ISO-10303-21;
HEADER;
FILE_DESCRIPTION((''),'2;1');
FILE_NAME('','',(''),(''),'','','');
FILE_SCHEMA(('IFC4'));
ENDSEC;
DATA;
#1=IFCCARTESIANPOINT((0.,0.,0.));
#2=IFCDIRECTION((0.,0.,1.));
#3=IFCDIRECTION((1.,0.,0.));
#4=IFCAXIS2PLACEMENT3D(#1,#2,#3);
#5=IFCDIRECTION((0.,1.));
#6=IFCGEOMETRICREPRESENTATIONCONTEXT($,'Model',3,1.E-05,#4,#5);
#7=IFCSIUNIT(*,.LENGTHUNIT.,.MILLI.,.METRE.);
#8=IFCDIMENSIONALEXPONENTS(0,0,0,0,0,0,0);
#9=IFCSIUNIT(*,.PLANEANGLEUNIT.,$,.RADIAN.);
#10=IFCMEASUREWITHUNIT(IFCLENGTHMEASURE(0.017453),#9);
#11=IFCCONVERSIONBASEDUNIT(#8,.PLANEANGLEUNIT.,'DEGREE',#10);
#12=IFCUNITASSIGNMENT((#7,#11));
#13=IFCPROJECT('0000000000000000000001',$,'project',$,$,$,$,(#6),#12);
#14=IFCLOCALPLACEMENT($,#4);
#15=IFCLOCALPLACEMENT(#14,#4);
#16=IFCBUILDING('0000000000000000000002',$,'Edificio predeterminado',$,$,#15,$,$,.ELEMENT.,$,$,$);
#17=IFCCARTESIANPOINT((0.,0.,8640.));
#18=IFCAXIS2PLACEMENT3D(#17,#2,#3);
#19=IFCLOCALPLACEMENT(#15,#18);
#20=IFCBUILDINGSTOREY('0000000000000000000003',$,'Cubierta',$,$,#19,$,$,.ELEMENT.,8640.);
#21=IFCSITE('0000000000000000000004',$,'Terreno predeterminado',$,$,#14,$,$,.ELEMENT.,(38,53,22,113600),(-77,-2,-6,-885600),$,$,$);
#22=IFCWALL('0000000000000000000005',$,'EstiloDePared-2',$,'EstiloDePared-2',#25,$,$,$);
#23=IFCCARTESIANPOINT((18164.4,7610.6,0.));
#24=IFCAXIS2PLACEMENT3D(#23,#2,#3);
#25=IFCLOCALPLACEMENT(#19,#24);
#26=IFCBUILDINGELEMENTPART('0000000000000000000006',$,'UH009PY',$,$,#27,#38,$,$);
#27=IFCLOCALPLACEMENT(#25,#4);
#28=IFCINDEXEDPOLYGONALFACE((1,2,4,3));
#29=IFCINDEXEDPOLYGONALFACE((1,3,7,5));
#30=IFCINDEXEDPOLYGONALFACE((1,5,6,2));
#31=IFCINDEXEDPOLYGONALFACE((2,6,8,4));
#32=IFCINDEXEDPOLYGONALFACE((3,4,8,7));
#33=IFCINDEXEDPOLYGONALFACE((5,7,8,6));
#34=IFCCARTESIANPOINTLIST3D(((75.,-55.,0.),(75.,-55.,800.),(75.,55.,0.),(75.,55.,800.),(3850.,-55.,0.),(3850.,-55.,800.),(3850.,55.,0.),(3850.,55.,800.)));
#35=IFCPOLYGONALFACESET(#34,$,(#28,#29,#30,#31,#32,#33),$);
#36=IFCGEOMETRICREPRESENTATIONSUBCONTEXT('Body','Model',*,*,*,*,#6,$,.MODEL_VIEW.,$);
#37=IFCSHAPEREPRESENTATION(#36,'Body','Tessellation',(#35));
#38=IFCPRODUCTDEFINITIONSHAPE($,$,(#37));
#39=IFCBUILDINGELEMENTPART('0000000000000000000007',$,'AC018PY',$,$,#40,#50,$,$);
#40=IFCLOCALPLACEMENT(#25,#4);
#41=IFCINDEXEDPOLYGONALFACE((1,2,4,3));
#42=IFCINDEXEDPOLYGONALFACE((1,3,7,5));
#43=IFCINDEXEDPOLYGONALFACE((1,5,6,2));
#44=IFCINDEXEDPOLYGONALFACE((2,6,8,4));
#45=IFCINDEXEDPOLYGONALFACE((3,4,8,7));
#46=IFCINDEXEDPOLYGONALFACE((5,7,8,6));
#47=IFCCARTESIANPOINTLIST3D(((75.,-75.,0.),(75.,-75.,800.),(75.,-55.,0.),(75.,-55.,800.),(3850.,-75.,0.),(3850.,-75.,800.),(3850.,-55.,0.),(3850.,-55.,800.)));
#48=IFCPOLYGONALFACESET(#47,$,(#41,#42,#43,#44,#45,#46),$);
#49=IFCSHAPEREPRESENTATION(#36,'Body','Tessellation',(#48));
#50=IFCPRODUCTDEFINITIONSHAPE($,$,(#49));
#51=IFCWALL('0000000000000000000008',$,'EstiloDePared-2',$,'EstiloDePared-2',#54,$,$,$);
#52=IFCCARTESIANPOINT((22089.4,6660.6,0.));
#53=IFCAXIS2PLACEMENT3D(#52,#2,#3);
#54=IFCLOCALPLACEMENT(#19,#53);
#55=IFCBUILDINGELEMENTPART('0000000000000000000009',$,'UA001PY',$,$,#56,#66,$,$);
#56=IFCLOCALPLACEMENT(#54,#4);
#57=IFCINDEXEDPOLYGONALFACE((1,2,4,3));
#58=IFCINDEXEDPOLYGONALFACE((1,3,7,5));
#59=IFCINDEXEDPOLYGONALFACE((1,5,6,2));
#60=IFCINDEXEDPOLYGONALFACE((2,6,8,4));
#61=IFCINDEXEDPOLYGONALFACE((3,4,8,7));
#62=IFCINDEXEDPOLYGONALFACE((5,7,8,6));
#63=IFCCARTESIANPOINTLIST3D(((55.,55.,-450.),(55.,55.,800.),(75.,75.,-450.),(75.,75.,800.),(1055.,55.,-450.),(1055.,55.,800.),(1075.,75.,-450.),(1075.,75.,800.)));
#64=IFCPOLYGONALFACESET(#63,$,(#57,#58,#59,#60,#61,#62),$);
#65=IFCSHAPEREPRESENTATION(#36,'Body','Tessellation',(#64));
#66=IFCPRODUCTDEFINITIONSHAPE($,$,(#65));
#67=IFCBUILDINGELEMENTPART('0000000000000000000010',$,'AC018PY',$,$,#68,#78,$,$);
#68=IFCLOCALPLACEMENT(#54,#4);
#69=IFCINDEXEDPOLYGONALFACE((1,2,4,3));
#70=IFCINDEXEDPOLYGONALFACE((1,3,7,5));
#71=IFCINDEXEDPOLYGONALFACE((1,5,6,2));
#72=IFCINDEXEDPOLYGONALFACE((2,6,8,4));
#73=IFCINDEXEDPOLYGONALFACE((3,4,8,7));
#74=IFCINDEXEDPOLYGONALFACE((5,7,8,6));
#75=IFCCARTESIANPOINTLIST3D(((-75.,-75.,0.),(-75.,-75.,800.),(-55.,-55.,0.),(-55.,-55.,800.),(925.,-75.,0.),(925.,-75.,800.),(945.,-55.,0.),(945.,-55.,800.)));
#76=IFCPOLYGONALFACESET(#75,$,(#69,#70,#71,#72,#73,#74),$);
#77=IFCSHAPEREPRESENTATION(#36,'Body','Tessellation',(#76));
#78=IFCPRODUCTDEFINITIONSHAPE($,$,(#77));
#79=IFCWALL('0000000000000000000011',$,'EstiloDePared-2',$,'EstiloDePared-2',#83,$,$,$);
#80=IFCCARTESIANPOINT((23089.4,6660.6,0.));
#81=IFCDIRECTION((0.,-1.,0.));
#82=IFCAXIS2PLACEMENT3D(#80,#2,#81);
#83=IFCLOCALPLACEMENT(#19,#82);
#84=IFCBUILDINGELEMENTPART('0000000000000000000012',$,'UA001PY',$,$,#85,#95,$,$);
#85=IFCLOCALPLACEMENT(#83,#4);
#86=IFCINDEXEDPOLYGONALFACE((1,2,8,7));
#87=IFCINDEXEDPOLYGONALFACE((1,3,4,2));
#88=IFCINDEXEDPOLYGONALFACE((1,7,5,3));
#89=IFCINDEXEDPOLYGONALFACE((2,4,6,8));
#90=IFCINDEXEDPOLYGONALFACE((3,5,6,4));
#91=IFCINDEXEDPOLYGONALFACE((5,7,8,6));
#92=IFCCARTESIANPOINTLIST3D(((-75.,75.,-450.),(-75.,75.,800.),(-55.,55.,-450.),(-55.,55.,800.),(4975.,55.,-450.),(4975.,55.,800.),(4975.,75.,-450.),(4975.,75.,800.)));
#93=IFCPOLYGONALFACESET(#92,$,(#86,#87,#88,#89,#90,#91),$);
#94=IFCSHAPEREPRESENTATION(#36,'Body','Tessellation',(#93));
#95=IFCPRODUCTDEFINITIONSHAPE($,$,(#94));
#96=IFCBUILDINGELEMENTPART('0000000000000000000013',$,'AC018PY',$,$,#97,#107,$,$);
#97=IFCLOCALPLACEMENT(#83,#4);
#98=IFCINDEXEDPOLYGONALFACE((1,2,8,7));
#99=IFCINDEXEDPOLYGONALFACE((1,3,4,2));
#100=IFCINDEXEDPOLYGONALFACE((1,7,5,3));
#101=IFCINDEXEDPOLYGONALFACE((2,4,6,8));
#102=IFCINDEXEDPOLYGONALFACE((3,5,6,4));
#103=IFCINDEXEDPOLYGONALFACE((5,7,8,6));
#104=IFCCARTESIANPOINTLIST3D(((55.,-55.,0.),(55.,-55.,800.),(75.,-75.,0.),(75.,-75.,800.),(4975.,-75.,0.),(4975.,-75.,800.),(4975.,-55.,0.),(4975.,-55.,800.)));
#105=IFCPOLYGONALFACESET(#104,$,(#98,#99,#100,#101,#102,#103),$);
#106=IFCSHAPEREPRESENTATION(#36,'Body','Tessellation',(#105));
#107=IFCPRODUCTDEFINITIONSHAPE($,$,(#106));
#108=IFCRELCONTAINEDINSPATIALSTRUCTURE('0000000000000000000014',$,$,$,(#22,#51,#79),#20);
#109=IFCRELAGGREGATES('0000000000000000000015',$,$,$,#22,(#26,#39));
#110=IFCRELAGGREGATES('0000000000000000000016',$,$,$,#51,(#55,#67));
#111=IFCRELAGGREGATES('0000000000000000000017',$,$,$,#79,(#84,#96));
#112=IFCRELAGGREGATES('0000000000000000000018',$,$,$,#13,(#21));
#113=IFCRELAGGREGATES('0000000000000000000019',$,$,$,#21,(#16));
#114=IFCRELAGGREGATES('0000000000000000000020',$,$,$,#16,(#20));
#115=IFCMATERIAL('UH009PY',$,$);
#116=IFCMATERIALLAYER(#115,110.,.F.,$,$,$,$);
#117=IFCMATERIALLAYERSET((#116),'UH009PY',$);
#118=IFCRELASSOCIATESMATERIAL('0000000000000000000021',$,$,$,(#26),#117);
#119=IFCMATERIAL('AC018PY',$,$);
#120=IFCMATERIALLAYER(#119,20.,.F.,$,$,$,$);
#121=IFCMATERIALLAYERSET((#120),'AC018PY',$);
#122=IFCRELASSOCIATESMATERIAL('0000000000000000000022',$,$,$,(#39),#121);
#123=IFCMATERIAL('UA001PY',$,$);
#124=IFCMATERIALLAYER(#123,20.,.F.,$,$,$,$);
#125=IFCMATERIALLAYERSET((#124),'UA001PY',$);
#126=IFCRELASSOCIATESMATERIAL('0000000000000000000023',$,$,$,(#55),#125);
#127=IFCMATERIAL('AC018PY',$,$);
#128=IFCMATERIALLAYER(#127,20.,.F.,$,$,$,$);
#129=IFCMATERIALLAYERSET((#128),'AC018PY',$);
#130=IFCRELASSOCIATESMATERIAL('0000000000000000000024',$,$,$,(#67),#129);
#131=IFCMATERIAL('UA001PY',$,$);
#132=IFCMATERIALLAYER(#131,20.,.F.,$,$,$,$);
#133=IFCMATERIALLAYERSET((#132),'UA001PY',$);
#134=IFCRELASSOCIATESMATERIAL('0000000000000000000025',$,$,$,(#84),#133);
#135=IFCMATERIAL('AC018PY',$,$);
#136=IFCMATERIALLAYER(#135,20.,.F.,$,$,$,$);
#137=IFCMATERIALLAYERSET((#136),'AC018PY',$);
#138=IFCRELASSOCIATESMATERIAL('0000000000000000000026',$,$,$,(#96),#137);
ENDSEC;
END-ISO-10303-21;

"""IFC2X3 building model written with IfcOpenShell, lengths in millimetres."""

from ifc_helpers import new_model, entity, si_unit, converted_unit, direction, frame, origin_with_axes, place, context, subcontext, project, spatial, polyline, outline, extrude, material, layer, layer_set, layer_usage, element, aggregate, save


model = new_model("IFC2X3")

# Units and contexts
model_context = context("Model", 3, precision=1e-05, world=origin_with_axes(), true_north=direction((0.0, 1.0)))
body_context = subcontext(model_context, "Body", "Model", "MODEL_VIEW")
ifc_project = project(units=[si_unit("LENGTHUNIT", "METRE", prefix="MILLI"), converted_unit("PLANEANGLEUNIT", "DEGREE", entity("IfcLengthMeasure", 0.017453), si_unit("PLANEANGLEUNIT", "RADIAN"), dimensions=[0, 0, 0, 0, 0, 0, 0])], contexts=[model_context])

# Site, building, storey
site_placement = place(None, origin_with_axes())
site = spatial("IfcSite", under=ifc_project, at=site_placement, Name="Terreno predeterminado", CompositionType="ELEMENT", RefLatitude=(38, 53, 22, 113600), RefLongitude=(-77, -2, -6, -885600))
building_placement = place(site_placement, origin_with_axes())
building = spatial("IfcBuilding", under=site, at=building_placement, Name="Edificio predeterminado", CompositionType="ELEMENT")
storey_placement = place(building_placement, frame((0.0, 0.0, 8640.0), z_axis=(0.0, 0.0, 1.0), x_axis=(1.0, 0.0, 0.0)))
storey = spatial("IfcBuildingStorey", under=building, at=storey_placement, Name="Cubierta", CompositionType="ELEMENT", Elevation=8640.0)

# Walls, building element parts
wall_1_placement = place(storey_placement, frame((18164.4, 7610.6, 0.0), z_axis=(0.0, 0.0, 1.0), x_axis=(1.0, 0.0, 0.0)))
wall_1 = element("IfcWall", 1, at=wall_1_placement, inside=storey, Name="EstiloDePared-2", ObjectType="EstiloDePared-2")
ifc_material_1 = material(Name="UH009PY")
ifc_layer_1 = layer(ifc_material_1, 110.0, ventilated=False)
ifc_layer_set_1 = layer_set([ifc_layer_1], Name="UH009PY")
ifc_layer_usage_1 = layer_usage(ifc_layer_set_1, "AXIS2", "NEGATIVE", -55.0)
building_element_part_1_placement = place(wall_1_placement, origin_with_axes())
building_element_part_1 = element("IfcBuildingElementPart", 2, at=building_element_part_1_placement, material=ifc_layer_usage_1, Name="UH009PY", context=body_context, shape_type="SweptSolid", body=[
    extrude(outline(polyline([(3850.0, 55.0), (3850.0, -55.0), (75.0, -55.0), (75.0, 55.0), (3850.0, 55.0)])), origin_with_axes(), (0.0, 0.0, 1.0), 800.0),
])
ifc_material_2 = material(Name="AC018PY")
ifc_layer_2 = layer(ifc_material_2, 20.0, ventilated=False)
ifc_layer_set_2 = layer_set([ifc_layer_2], Name="AC018PY")
ifc_layer_usage_2 = layer_usage(ifc_layer_set_2, "AXIS2", "NEGATIVE", 55.0)
building_element_part_2_placement = place(wall_1_placement, origin_with_axes())
building_element_part_2 = element("IfcBuildingElementPart", 3, at=building_element_part_2_placement, material=ifc_layer_usage_2, Name="AC018PY", context=body_context, shape_type="SweptSolid", body=[
    extrude(outline(polyline([(3850.0, -55.0), (3850.0, -75.0), (75.0, -75.0), (75.0, -55.0), (3850.0, -55.0)])), origin_with_axes(), (0.0, 0.0, 1.0), 800.0),
])
aggregate(wall_1, [building_element_part_1, building_element_part_2])
wall_2_placement = place(storey_placement, frame((22089.4, 6660.6, 0.0), z_axis=(0.0, 0.0, 1.0), x_axis=(1.0, 0.0, 0.0)))
wall_2 = element("IfcWall", 4, at=wall_2_placement, inside=storey, Name="EstiloDePared-2", ObjectType="EstiloDePared-2")
ifc_material_3 = material(Name="UA001PY")
ifc_layer_3 = layer(ifc_material_3, 20.0, ventilated=False)
ifc_layer_set_3 = layer_set([ifc_layer_3], Name="UA001PY")
ifc_layer_usage_3 = layer_usage(ifc_layer_set_3, "AXIS2", "NEGATIVE", -75.0)
building_element_part_3_placement = place(wall_2_placement, origin_with_axes())
building_element_part_3 = element("IfcBuildingElementPart", 5, at=building_element_part_3_placement, material=ifc_layer_usage_3, Name="UA001PY", context=body_context, shape_type="SweptSolid", body=[
    extrude(outline(polyline([(1075.0, 75.0), (1055.0, 55.0), (55.0, 55.0), (75.0, 75.0), (1075.0, 75.0)])), frame((0.0, 0.0, -450.0), z_axis=(0.0, 0.0, 1.0), x_axis=(1.0, 0.0, 0.0)), (0.0, 0.0, 1.0), 1250.0),
])
ifc_material_4 = material(Name="AC018PY")
ifc_layer_4 = layer(ifc_material_4, 20.0, ventilated=False)
ifc_layer_set_4 = layer_set([ifc_layer_4], Name="AC018PY")
ifc_layer_usage_4 = layer_usage(ifc_layer_set_4, "AXIS2", "NEGATIVE", 55.0)
building_element_part_4_placement = place(wall_2_placement, origin_with_axes())
building_element_part_4 = element("IfcBuildingElementPart", 6, at=building_element_part_4_placement, material=ifc_layer_usage_4, Name="AC018PY", context=body_context, shape_type="SweptSolid", body=[
    extrude(outline(polyline([(945.0, -55.0), (925.0, -75.0), (-75.0, -75.0), (-55.0, -55.0), (945.0, -55.0)])), origin_with_axes(), (0.0, 0.0, 1.0), 800.0),
])
aggregate(wall_2, [building_element_part_3, building_element_part_4])
wall_3_placement = place(storey_placement, frame((23089.4, 6660.6, 0.0), z_axis=(0.0, 0.0, 1.0), x_axis=(0.0, -1.0, 0.0)))
wall_3 = element("IfcWall", 7, at=wall_3_placement, inside=storey, Name="EstiloDePared-2", ObjectType="EstiloDePared-2")
ifc_material_5 = material(Name="UA001PY")
ifc_layer_5 = layer(ifc_material_5, 20.0, ventilated=False)
ifc_layer_set_5 = layer_set([ifc_layer_5], Name="UA001PY")
ifc_layer_usage_5 = layer_usage(ifc_layer_set_5, "AXIS2", "NEGATIVE", -75.0)
building_element_part_5_placement = place(wall_3_placement, origin_with_axes())
building_element_part_5 = element("IfcBuildingElementPart", 8, at=building_element_part_5_placement, material=ifc_layer_usage_5, Name="UA001PY", context=body_context, shape_type="SweptSolid", body=[
    extrude(outline(polyline([(4975.0, 75.0), (4975.0, 55.0), (-55.0, 55.0), (-75.0, 75.0), (4975.0, 75.0)])), frame((0.0, 0.0, -450.0), z_axis=(0.0, 0.0, 1.0), x_axis=(1.0, 0.0, 0.0)), (0.0, 0.0, 1.0), 1250.0),
])
ifc_material_6 = material(Name="AC018PY")
ifc_layer_6 = layer(ifc_material_6, 20.0, ventilated=False)
ifc_layer_set_6 = layer_set([ifc_layer_6], Name="AC018PY")
ifc_layer_usage_6 = layer_usage(ifc_layer_set_6, "AXIS2", "NEGATIVE", 55.0)
building_element_part_6_placement = place(wall_3_placement, origin_with_axes())
building_element_part_6 = element("IfcBuildingElementPart", 9, at=building_element_part_6_placement, material=ifc_layer_usage_6, Name="AC018PY", context=body_context, shape_type="SweptSolid", body=[
    extrude(outline(polyline([(4975.0, -55.0), (4975.0, -75.0), (75.0, -75.0), (55.0, -55.0), (4975.0, -55.0)])), origin_with_axes(), (0.0, 0.0, 1.0), 800.0),
])
aggregate(wall_3, [building_element_part_5, building_element_part_6])

save(model, "model.ifc")
